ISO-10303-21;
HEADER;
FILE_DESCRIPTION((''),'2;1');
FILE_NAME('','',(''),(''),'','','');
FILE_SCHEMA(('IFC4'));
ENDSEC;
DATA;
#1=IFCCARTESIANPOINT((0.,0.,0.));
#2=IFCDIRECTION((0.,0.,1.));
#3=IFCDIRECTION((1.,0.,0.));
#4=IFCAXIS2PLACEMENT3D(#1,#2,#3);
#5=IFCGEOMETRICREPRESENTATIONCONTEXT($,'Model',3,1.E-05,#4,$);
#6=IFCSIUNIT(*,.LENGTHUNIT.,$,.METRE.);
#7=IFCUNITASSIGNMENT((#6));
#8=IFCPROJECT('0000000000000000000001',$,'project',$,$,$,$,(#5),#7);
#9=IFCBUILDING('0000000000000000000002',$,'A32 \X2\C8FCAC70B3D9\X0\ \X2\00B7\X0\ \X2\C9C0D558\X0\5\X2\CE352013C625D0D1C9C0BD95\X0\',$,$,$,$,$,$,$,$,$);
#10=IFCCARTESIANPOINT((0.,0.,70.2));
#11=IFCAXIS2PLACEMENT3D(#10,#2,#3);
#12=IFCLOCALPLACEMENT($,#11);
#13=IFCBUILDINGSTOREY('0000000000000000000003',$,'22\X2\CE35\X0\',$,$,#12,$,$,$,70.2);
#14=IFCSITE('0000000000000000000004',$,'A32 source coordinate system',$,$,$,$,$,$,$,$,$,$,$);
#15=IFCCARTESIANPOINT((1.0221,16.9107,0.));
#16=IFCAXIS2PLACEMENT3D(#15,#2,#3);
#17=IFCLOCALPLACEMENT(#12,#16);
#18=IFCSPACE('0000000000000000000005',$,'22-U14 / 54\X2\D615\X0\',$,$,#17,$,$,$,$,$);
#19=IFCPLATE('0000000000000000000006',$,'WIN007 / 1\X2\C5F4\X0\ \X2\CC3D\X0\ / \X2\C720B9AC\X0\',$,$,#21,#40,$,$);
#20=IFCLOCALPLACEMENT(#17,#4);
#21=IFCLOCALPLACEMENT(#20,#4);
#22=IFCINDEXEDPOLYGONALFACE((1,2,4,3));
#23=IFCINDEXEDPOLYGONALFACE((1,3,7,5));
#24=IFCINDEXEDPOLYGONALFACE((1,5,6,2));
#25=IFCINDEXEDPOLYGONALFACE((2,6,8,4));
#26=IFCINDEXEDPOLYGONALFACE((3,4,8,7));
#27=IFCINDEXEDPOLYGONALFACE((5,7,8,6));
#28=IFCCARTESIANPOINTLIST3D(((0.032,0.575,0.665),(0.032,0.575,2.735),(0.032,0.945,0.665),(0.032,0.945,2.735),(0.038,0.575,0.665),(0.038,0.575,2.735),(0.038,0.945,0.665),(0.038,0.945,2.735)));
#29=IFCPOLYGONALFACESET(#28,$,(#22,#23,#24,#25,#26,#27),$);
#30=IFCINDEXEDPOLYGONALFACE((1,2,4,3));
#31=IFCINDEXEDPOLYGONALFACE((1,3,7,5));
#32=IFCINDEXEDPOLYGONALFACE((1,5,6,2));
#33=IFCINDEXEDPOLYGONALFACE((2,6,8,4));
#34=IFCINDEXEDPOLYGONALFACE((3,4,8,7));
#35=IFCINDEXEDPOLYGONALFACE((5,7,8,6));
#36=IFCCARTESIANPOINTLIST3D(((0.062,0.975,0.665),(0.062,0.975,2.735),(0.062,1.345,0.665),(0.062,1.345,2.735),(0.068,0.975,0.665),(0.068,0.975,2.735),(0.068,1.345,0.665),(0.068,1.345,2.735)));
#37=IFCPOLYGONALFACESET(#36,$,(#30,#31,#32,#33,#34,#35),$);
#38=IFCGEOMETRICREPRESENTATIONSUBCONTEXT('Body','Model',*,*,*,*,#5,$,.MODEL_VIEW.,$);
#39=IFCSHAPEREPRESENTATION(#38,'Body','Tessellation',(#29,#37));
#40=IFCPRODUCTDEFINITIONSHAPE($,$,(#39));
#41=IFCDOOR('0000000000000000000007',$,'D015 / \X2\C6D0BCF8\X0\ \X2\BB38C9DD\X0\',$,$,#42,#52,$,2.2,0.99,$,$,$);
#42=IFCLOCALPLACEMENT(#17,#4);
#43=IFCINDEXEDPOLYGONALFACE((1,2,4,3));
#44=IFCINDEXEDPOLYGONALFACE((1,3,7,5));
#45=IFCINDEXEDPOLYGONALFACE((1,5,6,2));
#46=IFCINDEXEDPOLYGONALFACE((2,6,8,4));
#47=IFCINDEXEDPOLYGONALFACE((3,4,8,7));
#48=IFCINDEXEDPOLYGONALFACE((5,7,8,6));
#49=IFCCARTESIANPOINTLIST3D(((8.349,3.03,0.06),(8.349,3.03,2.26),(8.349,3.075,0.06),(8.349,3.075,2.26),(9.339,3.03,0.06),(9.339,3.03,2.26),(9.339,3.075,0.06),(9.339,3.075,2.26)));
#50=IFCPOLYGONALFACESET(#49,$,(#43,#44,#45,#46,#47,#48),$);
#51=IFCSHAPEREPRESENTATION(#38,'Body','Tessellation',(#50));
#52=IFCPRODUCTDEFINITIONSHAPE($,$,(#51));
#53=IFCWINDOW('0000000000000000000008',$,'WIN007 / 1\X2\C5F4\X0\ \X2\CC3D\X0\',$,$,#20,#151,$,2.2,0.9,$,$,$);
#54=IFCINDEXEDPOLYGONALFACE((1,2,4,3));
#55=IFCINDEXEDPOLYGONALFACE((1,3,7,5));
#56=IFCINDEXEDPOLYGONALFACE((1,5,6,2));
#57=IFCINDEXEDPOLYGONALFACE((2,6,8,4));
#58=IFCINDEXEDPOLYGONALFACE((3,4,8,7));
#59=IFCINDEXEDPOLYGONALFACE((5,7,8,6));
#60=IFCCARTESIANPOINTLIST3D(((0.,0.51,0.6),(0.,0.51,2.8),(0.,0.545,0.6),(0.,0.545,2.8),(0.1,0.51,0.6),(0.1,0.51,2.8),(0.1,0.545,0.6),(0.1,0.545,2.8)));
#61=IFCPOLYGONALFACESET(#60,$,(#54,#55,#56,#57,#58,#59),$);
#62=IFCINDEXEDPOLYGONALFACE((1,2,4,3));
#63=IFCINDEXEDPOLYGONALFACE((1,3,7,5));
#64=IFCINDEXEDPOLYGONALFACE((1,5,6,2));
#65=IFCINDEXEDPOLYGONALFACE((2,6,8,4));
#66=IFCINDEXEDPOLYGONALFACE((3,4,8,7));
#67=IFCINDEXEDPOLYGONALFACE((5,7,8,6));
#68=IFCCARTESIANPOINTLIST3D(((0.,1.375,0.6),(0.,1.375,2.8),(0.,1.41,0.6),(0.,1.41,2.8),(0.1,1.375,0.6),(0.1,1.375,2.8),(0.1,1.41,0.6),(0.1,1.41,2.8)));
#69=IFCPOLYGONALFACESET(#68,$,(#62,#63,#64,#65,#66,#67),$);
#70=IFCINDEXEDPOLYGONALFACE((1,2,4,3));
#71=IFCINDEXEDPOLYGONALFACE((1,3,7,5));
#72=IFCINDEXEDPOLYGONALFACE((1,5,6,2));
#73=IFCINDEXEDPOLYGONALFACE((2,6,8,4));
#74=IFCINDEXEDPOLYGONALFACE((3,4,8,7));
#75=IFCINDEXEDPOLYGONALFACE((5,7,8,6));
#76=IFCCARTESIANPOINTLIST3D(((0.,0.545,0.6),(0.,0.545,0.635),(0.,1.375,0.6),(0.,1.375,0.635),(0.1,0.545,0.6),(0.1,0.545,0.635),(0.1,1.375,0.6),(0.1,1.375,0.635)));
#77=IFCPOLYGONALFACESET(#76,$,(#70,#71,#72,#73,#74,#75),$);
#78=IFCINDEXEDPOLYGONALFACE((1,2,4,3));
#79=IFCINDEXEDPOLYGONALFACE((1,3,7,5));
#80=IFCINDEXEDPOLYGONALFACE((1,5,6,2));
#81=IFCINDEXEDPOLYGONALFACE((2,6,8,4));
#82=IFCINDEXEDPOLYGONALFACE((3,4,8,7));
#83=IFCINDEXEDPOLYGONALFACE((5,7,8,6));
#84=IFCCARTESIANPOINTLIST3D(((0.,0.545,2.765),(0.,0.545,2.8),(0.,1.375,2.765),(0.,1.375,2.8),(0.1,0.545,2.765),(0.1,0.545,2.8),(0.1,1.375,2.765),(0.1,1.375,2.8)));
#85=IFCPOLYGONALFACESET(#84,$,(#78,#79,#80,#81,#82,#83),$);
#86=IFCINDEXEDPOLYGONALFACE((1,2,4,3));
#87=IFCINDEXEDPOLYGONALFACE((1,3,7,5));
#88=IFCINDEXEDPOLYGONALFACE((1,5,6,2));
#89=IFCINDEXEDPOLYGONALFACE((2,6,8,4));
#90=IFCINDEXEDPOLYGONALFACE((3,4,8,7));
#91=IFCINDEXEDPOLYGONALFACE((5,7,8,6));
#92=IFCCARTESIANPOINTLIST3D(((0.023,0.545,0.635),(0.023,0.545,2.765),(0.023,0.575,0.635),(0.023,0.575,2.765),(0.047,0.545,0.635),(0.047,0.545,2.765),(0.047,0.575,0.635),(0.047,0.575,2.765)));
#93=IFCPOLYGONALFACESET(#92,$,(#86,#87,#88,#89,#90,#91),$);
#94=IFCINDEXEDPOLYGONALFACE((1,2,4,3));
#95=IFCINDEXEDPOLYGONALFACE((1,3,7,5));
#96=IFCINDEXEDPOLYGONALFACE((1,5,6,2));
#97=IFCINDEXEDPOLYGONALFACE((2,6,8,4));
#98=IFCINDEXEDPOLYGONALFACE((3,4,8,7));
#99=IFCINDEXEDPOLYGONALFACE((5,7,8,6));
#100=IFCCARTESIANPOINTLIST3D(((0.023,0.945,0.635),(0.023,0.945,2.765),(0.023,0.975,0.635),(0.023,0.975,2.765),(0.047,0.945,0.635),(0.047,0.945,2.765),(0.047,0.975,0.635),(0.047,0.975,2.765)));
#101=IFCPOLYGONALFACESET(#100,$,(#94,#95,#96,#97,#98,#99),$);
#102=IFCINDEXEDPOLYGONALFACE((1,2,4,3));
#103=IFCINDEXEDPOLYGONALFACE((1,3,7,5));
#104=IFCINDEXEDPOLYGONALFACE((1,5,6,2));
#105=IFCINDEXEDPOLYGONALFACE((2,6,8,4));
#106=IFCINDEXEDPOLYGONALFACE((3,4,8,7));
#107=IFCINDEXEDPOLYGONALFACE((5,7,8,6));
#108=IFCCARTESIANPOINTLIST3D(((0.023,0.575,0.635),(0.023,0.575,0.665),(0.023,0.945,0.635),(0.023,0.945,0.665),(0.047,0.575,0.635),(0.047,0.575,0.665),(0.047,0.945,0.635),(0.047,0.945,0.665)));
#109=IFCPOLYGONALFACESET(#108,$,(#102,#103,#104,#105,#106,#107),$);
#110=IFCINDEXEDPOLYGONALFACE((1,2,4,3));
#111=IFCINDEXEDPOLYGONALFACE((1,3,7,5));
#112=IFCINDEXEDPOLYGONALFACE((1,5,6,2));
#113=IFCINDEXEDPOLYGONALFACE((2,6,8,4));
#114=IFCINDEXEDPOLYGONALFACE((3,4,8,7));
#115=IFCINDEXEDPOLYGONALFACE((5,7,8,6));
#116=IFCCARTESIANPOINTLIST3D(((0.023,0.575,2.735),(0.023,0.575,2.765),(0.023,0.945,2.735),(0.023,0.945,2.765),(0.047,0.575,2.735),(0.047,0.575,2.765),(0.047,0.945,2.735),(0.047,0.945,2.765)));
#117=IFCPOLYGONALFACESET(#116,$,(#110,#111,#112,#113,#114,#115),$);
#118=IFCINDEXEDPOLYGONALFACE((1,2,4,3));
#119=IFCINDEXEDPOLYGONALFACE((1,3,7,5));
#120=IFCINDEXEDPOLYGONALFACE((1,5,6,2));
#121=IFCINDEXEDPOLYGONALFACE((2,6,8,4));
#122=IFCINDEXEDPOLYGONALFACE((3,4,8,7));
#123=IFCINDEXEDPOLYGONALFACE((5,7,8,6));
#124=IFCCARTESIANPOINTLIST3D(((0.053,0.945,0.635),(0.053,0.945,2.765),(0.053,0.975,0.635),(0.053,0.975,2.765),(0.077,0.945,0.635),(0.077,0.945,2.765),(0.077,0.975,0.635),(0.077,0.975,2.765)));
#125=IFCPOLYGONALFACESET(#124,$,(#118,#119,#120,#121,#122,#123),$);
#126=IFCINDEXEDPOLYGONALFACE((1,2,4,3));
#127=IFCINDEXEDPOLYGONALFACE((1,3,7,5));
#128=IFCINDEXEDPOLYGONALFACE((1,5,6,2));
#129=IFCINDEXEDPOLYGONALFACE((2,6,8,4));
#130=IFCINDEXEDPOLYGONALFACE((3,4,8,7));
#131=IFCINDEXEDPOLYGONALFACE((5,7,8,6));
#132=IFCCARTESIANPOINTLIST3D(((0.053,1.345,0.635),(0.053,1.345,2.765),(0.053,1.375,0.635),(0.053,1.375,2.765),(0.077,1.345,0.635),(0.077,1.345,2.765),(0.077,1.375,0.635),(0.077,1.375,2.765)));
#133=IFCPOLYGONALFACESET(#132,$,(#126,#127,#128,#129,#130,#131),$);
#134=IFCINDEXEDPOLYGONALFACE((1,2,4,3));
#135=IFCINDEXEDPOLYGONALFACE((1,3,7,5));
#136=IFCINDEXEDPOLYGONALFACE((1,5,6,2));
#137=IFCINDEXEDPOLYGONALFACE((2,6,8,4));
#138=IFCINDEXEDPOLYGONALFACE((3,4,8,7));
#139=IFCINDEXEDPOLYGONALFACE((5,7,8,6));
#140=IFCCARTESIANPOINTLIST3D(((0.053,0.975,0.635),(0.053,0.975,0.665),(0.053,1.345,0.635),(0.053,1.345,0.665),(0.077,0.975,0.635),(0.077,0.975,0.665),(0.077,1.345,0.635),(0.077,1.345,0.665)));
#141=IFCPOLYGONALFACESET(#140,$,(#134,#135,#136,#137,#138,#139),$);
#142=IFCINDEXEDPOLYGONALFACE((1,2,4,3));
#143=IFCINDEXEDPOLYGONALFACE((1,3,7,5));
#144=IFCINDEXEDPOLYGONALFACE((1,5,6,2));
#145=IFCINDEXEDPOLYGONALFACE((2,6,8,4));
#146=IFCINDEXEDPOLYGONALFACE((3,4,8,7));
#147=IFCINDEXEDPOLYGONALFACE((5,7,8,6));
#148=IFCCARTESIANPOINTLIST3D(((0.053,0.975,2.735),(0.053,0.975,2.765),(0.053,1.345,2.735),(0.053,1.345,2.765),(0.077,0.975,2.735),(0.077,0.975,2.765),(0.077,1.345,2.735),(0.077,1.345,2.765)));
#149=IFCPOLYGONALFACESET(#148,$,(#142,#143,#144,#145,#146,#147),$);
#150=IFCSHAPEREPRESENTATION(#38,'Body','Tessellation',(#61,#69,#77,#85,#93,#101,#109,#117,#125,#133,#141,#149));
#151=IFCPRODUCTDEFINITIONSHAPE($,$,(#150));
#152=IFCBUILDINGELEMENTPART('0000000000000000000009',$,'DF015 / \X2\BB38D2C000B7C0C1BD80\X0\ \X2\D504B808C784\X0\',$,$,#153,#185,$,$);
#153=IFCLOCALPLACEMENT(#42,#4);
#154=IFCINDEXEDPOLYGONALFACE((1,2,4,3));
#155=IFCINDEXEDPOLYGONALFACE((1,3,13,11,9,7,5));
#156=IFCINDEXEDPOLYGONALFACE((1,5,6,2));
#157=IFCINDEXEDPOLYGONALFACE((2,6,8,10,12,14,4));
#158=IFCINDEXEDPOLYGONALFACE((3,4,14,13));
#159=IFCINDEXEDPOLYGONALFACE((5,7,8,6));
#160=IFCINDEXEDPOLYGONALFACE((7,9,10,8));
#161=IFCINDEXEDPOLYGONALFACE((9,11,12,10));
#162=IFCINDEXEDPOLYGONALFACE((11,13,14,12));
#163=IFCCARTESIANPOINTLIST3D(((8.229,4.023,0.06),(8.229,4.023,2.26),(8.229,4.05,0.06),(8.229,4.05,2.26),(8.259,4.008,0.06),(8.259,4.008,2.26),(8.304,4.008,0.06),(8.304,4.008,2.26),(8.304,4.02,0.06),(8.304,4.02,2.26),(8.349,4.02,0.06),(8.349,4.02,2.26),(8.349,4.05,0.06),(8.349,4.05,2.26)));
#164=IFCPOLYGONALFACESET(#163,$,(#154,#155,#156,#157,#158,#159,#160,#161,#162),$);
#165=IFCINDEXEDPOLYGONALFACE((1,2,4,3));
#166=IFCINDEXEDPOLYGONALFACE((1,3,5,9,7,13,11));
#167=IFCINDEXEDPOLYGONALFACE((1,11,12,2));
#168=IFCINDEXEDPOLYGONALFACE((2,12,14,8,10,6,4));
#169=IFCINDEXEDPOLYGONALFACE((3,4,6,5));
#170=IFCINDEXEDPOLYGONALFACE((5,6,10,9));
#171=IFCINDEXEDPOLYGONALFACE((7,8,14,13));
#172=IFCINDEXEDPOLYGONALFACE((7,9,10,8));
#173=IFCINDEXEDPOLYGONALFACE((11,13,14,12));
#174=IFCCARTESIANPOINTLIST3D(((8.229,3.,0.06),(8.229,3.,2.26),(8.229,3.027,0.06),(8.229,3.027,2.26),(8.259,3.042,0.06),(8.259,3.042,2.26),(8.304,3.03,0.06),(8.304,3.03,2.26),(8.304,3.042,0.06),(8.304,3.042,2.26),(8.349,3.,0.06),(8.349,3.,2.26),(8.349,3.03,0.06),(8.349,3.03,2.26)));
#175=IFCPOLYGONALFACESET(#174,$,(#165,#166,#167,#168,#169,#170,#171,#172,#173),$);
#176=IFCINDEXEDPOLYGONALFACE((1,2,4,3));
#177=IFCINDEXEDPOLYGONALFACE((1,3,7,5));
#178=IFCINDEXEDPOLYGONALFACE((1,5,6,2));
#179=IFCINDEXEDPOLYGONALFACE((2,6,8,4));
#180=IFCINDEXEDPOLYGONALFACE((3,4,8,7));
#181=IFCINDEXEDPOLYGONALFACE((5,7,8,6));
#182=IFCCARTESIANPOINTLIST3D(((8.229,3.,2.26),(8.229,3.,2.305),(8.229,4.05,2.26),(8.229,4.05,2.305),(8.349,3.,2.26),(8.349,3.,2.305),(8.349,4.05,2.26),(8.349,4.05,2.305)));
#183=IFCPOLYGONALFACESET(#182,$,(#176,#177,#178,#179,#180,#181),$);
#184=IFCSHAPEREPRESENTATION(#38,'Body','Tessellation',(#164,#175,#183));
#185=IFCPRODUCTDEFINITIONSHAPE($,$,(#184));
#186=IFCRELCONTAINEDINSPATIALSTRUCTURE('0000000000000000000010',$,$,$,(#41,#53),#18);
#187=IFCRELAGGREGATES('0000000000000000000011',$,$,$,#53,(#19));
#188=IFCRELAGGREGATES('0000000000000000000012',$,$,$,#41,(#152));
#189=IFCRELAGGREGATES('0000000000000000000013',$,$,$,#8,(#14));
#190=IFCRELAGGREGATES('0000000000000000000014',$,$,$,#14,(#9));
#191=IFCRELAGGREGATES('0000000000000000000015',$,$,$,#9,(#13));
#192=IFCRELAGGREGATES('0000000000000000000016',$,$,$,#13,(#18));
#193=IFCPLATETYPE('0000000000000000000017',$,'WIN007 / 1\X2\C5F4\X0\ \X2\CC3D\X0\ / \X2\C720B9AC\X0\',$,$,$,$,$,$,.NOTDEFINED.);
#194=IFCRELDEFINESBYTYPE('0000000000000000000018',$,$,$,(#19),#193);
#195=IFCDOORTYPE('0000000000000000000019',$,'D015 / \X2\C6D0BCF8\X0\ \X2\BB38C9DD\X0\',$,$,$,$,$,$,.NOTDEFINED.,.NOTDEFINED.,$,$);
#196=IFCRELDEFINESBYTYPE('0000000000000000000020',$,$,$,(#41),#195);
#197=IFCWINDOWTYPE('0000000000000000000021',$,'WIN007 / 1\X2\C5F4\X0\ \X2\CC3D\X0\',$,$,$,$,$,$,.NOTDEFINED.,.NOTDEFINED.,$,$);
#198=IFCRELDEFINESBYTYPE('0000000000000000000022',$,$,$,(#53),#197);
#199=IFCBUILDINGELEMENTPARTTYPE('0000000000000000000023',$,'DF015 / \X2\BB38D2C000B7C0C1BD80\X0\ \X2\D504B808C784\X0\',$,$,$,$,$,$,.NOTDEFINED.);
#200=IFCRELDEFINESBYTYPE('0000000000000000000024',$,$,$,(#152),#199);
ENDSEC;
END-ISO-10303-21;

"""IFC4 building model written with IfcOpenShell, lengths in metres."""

from ifc_helpers import new_model, si_unit, frame, origin, origin_with_axes, place, context, subcontext, project, spatial, polyline, outline, extrude, source, transform, mapped, type_object, type_shapes, element, aggregate, save


model = new_model("IFC4")

# Units and contexts
model_context = context("Model", 3, precision=1e-05, world=origin_with_axes())
body_context = subcontext(model_context, "Body", "Model", "MODEL_VIEW")
ifc_project = project(units=[si_unit("LENGTHUNIT", "METRE")], contexts=[model_context])

# Plate
plate_type_1 = type_object("IfcPlateType", Name="WIN007 / 1열 창 / 유리", PredefinedType="NOTDEFINED")
shared_shape_1 = source(origin(), body_context, "Body", "SweptSolid", [
    extrude(outline(polyline([(0.032, 0.575), (0.032, 0.945), (0.038, 0.945), (0.038, 0.575), (0.032, 0.575)])), frame((0.0, 0.0, 0.665)), (0.0, 0.0, 1.0), 2.07),
    extrude(outline(polyline([(0.062, 0.975), (0.062, 1.345), (0.068, 1.345), (0.068, 0.975), (0.062, 0.975)])), frame((0.0, 0.0, 0.665)), (0.0, 0.0, 1.0), 2.07),
])
type_shapes(plate_type_1, [shared_shape_1])
storey_placement = place(None, frame((0.0, 0.0, 70.2), z_axis=(0.0, 0.0, 1.0), x_axis=(1.0, 0.0, 0.0)))
space_1_placement = place(storey_placement, frame((1.0221, 16.9107, 0.0), z_axis=(0.0, 0.0, 1.0), x_axis=(1.0, 0.0, 0.0)))
window_1_placement = place(space_1_placement, origin_with_axes())
plate_1_placement = place(window_1_placement, origin_with_axes())
plate_1 = element("IfcPlate", 1, at=plate_1_placement, type_object=plate_type_1, Name="WIN007 / 1열 창 / 유리", context=body_context, shape_type="MappedRepresentation", body=[
    mapped(shared_shape_1, transform((0.0, 0.0, 0.0), scale=1.0)),
])

# Site, building, storey, space
site = spatial("IfcSite", under=ifc_project, Name="A32 source coordinate system")
building = spatial("IfcBuilding", under=site, Name="A32 주거동 · 지하5층–옥탑지붕")
storey = spatial("IfcBuildingStorey", under=building, at=storey_placement, Name="22층", Elevation=70.2)
space_1 = spatial("IfcSpace", under=storey, at=space_1_placement, Name="22-U14 / 54형")

# Door
door_type_1 = type_object("IfcDoorType", Name="D015 / 원본 문짝", OperationType="NOTDEFINED", PredefinedType="NOTDEFINED")
shared_shape_2 = source(origin(), body_context, "Body", "SweptSolid", [
    extrude(outline(polyline([(9.339, 3.075), (9.339, 3.03), (8.349, 3.03), (8.349, 3.075), (9.339, 3.075)])), frame((0.0, 0.0, 0.06)), (0.0, 0.0, 1.0), 2.2),
])
type_shapes(door_type_1, [shared_shape_2])
door_1_placement = place(space_1_placement, origin_with_axes())
door_1 = element("IfcDoor", 2, at=door_1_placement, inside=space_1, type_object=door_type_1, Name="D015 / 원본 문짝", OverallHeight=2.2, OverallWidth=0.99, context=body_context, shape_type="MappedRepresentation", body=[
    mapped(shared_shape_2, transform((0.0, 0.0, 0.0), scale=1.0)),
])

# Window
window_type_1 = type_object("IfcWindowType", Name="WIN007 / 1열 창", PartitioningType="NOTDEFINED", PredefinedType="NOTDEFINED")
shared_shape_3 = source(origin(), body_context, "Body", "SweptSolid", [
    extrude(outline(polyline([(0.0, 0.51), (0.0, 0.545), (0.1, 0.545), (0.1, 0.51), (0.0, 0.51)])), frame((0.0, 0.0, 0.6)), (0.0, 0.0, 1.0), 2.2),
    extrude(outline(polyline([(0.0, 1.375), (0.0, 1.41), (0.1, 1.41), (0.1, 1.375), (0.0, 1.375)])), frame((0.0, 0.0, 0.6)), (0.0, 0.0, 1.0), 2.2),
    extrude(outline(polyline([(0.0, 0.545), (0.0, 1.375), (0.1, 1.375), (0.1, 0.545), (0.0, 0.545)])), frame((0.0, 0.0, 0.6)), (0.0, 0.0, 1.0), 0.035),
    extrude(outline(polyline([(0.0, 0.545), (0.0, 1.375), (0.1, 1.375), (0.1, 0.545), (0.0, 0.545)])), frame((0.0, 0.0, 2.765)), (0.0, 0.0, 1.0), 0.035),
    extrude(outline(polyline([(0.023, 0.545), (0.023, 0.575), (0.047, 0.575), (0.047, 0.545), (0.023, 0.545)])), frame((0.0, 0.0, 0.635)), (0.0, 0.0, 1.0), 2.13),
    extrude(outline(polyline([(0.023, 0.945), (0.023, 0.975), (0.047, 0.975), (0.047, 0.945), (0.023, 0.945)])), frame((0.0, 0.0, 0.635)), (0.0, 0.0, 1.0), 2.13),
    extrude(outline(polyline([(0.023, 0.575), (0.023, 0.945), (0.047, 0.945), (0.047, 0.575), (0.023, 0.575)])), frame((0.0, 0.0, 0.635)), (0.0, 0.0, 1.0), 0.03),
    extrude(outline(polyline([(0.023, 0.575), (0.023, 0.945), (0.047, 0.945), (0.047, 0.575), (0.023, 0.575)])), frame((0.0, 0.0, 2.735)), (0.0, 0.0, 1.0), 0.03),
    extrude(outline(polyline([(0.053, 0.945), (0.053, 0.975), (0.077, 0.975), (0.077, 0.945), (0.053, 0.945)])), frame((0.0, 0.0, 0.635)), (0.0, 0.0, 1.0), 2.13),
    extrude(outline(polyline([(0.053, 1.345), (0.053, 1.375), (0.077, 1.375), (0.077, 1.345), (0.053, 1.345)])), frame((0.0, 0.0, 0.635)), (0.0, 0.0, 1.0), 2.13),
    extrude(outline(polyline([(0.053, 0.975), (0.053, 1.345), (0.077, 1.345), (0.077, 0.975), (0.053, 0.975)])), frame((0.0, 0.0, 0.635)), (0.0, 0.0, 1.0), 0.03),
    extrude(outline(polyline([(0.053, 0.975), (0.053, 1.345), (0.077, 1.345), (0.077, 0.975), (0.053, 0.975)])), frame((0.0, 0.0, 2.735)), (0.0, 0.0, 1.0), 0.03),
])
type_shapes(window_type_1, [shared_shape_3])
window_1 = element("IfcWindow", 3, at=window_1_placement, inside=space_1, type_object=window_type_1, Name="WIN007 / 1열 창", OverallHeight=2.2, OverallWidth=0.9, context=body_context, shape_type="MappedRepresentation", body=[
    mapped(shared_shape_3, transform((0.0, 0.0, 0.0), scale=1.0)),
])
aggregate(window_1, [plate_1])

# Building element part
building_element_part_type_1 = type_object("IfcBuildingElementPartType", Name="DF015 / 문틀·상부 프레임", PredefinedType="NOTDEFINED")
shared_shape_4 = source(origin(), body_context, "Body", "SweptSolid", [
    extrude(outline(polyline([(8.349, 4.02), (8.304, 4.02), (8.304, 4.008), (8.259, 4.008), (8.229, 4.023), (8.229, 4.05), (8.349, 4.05), (8.349, 4.02)])), frame((0.0, 0.0, 0.06)), (0.0, 0.0, 1.0), 2.2),
    extrude(outline(polyline([(8.229, 3.0), (8.229, 3.027), (8.259, 3.042), (8.304, 3.042), (8.304, 3.03), (8.349, 3.03), (8.349, 3.0), (8.229, 3.0)])), frame((0.0, 0.0, 0.06)), (0.0, 0.0, 1.0), 2.2),
    extrude(outline(polyline([(8.229, 3.0), (8.229, 4.05), (8.349, 4.05), (8.349, 3.0), (8.229, 3.0)])), frame((0.0, 0.0, 2.26)), (0.0, 0.0, 1.0), 0.045),
])
type_shapes(building_element_part_type_1, [shared_shape_4])
building_element_part_1_placement = place(door_1_placement, origin_with_axes())
building_element_part_1 = element("IfcBuildingElementPart", 4, at=building_element_part_1_placement, type_object=building_element_part_type_1, Name="DF015 / 문틀·상부 프레임", context=body_context, shape_type="MappedRepresentation", body=[
    mapped(shared_shape_4, transform((0.0, 0.0, 0.0), scale=1.0)),
])
aggregate(door_1, [building_element_part_1])

save(model, "model.ifc")
